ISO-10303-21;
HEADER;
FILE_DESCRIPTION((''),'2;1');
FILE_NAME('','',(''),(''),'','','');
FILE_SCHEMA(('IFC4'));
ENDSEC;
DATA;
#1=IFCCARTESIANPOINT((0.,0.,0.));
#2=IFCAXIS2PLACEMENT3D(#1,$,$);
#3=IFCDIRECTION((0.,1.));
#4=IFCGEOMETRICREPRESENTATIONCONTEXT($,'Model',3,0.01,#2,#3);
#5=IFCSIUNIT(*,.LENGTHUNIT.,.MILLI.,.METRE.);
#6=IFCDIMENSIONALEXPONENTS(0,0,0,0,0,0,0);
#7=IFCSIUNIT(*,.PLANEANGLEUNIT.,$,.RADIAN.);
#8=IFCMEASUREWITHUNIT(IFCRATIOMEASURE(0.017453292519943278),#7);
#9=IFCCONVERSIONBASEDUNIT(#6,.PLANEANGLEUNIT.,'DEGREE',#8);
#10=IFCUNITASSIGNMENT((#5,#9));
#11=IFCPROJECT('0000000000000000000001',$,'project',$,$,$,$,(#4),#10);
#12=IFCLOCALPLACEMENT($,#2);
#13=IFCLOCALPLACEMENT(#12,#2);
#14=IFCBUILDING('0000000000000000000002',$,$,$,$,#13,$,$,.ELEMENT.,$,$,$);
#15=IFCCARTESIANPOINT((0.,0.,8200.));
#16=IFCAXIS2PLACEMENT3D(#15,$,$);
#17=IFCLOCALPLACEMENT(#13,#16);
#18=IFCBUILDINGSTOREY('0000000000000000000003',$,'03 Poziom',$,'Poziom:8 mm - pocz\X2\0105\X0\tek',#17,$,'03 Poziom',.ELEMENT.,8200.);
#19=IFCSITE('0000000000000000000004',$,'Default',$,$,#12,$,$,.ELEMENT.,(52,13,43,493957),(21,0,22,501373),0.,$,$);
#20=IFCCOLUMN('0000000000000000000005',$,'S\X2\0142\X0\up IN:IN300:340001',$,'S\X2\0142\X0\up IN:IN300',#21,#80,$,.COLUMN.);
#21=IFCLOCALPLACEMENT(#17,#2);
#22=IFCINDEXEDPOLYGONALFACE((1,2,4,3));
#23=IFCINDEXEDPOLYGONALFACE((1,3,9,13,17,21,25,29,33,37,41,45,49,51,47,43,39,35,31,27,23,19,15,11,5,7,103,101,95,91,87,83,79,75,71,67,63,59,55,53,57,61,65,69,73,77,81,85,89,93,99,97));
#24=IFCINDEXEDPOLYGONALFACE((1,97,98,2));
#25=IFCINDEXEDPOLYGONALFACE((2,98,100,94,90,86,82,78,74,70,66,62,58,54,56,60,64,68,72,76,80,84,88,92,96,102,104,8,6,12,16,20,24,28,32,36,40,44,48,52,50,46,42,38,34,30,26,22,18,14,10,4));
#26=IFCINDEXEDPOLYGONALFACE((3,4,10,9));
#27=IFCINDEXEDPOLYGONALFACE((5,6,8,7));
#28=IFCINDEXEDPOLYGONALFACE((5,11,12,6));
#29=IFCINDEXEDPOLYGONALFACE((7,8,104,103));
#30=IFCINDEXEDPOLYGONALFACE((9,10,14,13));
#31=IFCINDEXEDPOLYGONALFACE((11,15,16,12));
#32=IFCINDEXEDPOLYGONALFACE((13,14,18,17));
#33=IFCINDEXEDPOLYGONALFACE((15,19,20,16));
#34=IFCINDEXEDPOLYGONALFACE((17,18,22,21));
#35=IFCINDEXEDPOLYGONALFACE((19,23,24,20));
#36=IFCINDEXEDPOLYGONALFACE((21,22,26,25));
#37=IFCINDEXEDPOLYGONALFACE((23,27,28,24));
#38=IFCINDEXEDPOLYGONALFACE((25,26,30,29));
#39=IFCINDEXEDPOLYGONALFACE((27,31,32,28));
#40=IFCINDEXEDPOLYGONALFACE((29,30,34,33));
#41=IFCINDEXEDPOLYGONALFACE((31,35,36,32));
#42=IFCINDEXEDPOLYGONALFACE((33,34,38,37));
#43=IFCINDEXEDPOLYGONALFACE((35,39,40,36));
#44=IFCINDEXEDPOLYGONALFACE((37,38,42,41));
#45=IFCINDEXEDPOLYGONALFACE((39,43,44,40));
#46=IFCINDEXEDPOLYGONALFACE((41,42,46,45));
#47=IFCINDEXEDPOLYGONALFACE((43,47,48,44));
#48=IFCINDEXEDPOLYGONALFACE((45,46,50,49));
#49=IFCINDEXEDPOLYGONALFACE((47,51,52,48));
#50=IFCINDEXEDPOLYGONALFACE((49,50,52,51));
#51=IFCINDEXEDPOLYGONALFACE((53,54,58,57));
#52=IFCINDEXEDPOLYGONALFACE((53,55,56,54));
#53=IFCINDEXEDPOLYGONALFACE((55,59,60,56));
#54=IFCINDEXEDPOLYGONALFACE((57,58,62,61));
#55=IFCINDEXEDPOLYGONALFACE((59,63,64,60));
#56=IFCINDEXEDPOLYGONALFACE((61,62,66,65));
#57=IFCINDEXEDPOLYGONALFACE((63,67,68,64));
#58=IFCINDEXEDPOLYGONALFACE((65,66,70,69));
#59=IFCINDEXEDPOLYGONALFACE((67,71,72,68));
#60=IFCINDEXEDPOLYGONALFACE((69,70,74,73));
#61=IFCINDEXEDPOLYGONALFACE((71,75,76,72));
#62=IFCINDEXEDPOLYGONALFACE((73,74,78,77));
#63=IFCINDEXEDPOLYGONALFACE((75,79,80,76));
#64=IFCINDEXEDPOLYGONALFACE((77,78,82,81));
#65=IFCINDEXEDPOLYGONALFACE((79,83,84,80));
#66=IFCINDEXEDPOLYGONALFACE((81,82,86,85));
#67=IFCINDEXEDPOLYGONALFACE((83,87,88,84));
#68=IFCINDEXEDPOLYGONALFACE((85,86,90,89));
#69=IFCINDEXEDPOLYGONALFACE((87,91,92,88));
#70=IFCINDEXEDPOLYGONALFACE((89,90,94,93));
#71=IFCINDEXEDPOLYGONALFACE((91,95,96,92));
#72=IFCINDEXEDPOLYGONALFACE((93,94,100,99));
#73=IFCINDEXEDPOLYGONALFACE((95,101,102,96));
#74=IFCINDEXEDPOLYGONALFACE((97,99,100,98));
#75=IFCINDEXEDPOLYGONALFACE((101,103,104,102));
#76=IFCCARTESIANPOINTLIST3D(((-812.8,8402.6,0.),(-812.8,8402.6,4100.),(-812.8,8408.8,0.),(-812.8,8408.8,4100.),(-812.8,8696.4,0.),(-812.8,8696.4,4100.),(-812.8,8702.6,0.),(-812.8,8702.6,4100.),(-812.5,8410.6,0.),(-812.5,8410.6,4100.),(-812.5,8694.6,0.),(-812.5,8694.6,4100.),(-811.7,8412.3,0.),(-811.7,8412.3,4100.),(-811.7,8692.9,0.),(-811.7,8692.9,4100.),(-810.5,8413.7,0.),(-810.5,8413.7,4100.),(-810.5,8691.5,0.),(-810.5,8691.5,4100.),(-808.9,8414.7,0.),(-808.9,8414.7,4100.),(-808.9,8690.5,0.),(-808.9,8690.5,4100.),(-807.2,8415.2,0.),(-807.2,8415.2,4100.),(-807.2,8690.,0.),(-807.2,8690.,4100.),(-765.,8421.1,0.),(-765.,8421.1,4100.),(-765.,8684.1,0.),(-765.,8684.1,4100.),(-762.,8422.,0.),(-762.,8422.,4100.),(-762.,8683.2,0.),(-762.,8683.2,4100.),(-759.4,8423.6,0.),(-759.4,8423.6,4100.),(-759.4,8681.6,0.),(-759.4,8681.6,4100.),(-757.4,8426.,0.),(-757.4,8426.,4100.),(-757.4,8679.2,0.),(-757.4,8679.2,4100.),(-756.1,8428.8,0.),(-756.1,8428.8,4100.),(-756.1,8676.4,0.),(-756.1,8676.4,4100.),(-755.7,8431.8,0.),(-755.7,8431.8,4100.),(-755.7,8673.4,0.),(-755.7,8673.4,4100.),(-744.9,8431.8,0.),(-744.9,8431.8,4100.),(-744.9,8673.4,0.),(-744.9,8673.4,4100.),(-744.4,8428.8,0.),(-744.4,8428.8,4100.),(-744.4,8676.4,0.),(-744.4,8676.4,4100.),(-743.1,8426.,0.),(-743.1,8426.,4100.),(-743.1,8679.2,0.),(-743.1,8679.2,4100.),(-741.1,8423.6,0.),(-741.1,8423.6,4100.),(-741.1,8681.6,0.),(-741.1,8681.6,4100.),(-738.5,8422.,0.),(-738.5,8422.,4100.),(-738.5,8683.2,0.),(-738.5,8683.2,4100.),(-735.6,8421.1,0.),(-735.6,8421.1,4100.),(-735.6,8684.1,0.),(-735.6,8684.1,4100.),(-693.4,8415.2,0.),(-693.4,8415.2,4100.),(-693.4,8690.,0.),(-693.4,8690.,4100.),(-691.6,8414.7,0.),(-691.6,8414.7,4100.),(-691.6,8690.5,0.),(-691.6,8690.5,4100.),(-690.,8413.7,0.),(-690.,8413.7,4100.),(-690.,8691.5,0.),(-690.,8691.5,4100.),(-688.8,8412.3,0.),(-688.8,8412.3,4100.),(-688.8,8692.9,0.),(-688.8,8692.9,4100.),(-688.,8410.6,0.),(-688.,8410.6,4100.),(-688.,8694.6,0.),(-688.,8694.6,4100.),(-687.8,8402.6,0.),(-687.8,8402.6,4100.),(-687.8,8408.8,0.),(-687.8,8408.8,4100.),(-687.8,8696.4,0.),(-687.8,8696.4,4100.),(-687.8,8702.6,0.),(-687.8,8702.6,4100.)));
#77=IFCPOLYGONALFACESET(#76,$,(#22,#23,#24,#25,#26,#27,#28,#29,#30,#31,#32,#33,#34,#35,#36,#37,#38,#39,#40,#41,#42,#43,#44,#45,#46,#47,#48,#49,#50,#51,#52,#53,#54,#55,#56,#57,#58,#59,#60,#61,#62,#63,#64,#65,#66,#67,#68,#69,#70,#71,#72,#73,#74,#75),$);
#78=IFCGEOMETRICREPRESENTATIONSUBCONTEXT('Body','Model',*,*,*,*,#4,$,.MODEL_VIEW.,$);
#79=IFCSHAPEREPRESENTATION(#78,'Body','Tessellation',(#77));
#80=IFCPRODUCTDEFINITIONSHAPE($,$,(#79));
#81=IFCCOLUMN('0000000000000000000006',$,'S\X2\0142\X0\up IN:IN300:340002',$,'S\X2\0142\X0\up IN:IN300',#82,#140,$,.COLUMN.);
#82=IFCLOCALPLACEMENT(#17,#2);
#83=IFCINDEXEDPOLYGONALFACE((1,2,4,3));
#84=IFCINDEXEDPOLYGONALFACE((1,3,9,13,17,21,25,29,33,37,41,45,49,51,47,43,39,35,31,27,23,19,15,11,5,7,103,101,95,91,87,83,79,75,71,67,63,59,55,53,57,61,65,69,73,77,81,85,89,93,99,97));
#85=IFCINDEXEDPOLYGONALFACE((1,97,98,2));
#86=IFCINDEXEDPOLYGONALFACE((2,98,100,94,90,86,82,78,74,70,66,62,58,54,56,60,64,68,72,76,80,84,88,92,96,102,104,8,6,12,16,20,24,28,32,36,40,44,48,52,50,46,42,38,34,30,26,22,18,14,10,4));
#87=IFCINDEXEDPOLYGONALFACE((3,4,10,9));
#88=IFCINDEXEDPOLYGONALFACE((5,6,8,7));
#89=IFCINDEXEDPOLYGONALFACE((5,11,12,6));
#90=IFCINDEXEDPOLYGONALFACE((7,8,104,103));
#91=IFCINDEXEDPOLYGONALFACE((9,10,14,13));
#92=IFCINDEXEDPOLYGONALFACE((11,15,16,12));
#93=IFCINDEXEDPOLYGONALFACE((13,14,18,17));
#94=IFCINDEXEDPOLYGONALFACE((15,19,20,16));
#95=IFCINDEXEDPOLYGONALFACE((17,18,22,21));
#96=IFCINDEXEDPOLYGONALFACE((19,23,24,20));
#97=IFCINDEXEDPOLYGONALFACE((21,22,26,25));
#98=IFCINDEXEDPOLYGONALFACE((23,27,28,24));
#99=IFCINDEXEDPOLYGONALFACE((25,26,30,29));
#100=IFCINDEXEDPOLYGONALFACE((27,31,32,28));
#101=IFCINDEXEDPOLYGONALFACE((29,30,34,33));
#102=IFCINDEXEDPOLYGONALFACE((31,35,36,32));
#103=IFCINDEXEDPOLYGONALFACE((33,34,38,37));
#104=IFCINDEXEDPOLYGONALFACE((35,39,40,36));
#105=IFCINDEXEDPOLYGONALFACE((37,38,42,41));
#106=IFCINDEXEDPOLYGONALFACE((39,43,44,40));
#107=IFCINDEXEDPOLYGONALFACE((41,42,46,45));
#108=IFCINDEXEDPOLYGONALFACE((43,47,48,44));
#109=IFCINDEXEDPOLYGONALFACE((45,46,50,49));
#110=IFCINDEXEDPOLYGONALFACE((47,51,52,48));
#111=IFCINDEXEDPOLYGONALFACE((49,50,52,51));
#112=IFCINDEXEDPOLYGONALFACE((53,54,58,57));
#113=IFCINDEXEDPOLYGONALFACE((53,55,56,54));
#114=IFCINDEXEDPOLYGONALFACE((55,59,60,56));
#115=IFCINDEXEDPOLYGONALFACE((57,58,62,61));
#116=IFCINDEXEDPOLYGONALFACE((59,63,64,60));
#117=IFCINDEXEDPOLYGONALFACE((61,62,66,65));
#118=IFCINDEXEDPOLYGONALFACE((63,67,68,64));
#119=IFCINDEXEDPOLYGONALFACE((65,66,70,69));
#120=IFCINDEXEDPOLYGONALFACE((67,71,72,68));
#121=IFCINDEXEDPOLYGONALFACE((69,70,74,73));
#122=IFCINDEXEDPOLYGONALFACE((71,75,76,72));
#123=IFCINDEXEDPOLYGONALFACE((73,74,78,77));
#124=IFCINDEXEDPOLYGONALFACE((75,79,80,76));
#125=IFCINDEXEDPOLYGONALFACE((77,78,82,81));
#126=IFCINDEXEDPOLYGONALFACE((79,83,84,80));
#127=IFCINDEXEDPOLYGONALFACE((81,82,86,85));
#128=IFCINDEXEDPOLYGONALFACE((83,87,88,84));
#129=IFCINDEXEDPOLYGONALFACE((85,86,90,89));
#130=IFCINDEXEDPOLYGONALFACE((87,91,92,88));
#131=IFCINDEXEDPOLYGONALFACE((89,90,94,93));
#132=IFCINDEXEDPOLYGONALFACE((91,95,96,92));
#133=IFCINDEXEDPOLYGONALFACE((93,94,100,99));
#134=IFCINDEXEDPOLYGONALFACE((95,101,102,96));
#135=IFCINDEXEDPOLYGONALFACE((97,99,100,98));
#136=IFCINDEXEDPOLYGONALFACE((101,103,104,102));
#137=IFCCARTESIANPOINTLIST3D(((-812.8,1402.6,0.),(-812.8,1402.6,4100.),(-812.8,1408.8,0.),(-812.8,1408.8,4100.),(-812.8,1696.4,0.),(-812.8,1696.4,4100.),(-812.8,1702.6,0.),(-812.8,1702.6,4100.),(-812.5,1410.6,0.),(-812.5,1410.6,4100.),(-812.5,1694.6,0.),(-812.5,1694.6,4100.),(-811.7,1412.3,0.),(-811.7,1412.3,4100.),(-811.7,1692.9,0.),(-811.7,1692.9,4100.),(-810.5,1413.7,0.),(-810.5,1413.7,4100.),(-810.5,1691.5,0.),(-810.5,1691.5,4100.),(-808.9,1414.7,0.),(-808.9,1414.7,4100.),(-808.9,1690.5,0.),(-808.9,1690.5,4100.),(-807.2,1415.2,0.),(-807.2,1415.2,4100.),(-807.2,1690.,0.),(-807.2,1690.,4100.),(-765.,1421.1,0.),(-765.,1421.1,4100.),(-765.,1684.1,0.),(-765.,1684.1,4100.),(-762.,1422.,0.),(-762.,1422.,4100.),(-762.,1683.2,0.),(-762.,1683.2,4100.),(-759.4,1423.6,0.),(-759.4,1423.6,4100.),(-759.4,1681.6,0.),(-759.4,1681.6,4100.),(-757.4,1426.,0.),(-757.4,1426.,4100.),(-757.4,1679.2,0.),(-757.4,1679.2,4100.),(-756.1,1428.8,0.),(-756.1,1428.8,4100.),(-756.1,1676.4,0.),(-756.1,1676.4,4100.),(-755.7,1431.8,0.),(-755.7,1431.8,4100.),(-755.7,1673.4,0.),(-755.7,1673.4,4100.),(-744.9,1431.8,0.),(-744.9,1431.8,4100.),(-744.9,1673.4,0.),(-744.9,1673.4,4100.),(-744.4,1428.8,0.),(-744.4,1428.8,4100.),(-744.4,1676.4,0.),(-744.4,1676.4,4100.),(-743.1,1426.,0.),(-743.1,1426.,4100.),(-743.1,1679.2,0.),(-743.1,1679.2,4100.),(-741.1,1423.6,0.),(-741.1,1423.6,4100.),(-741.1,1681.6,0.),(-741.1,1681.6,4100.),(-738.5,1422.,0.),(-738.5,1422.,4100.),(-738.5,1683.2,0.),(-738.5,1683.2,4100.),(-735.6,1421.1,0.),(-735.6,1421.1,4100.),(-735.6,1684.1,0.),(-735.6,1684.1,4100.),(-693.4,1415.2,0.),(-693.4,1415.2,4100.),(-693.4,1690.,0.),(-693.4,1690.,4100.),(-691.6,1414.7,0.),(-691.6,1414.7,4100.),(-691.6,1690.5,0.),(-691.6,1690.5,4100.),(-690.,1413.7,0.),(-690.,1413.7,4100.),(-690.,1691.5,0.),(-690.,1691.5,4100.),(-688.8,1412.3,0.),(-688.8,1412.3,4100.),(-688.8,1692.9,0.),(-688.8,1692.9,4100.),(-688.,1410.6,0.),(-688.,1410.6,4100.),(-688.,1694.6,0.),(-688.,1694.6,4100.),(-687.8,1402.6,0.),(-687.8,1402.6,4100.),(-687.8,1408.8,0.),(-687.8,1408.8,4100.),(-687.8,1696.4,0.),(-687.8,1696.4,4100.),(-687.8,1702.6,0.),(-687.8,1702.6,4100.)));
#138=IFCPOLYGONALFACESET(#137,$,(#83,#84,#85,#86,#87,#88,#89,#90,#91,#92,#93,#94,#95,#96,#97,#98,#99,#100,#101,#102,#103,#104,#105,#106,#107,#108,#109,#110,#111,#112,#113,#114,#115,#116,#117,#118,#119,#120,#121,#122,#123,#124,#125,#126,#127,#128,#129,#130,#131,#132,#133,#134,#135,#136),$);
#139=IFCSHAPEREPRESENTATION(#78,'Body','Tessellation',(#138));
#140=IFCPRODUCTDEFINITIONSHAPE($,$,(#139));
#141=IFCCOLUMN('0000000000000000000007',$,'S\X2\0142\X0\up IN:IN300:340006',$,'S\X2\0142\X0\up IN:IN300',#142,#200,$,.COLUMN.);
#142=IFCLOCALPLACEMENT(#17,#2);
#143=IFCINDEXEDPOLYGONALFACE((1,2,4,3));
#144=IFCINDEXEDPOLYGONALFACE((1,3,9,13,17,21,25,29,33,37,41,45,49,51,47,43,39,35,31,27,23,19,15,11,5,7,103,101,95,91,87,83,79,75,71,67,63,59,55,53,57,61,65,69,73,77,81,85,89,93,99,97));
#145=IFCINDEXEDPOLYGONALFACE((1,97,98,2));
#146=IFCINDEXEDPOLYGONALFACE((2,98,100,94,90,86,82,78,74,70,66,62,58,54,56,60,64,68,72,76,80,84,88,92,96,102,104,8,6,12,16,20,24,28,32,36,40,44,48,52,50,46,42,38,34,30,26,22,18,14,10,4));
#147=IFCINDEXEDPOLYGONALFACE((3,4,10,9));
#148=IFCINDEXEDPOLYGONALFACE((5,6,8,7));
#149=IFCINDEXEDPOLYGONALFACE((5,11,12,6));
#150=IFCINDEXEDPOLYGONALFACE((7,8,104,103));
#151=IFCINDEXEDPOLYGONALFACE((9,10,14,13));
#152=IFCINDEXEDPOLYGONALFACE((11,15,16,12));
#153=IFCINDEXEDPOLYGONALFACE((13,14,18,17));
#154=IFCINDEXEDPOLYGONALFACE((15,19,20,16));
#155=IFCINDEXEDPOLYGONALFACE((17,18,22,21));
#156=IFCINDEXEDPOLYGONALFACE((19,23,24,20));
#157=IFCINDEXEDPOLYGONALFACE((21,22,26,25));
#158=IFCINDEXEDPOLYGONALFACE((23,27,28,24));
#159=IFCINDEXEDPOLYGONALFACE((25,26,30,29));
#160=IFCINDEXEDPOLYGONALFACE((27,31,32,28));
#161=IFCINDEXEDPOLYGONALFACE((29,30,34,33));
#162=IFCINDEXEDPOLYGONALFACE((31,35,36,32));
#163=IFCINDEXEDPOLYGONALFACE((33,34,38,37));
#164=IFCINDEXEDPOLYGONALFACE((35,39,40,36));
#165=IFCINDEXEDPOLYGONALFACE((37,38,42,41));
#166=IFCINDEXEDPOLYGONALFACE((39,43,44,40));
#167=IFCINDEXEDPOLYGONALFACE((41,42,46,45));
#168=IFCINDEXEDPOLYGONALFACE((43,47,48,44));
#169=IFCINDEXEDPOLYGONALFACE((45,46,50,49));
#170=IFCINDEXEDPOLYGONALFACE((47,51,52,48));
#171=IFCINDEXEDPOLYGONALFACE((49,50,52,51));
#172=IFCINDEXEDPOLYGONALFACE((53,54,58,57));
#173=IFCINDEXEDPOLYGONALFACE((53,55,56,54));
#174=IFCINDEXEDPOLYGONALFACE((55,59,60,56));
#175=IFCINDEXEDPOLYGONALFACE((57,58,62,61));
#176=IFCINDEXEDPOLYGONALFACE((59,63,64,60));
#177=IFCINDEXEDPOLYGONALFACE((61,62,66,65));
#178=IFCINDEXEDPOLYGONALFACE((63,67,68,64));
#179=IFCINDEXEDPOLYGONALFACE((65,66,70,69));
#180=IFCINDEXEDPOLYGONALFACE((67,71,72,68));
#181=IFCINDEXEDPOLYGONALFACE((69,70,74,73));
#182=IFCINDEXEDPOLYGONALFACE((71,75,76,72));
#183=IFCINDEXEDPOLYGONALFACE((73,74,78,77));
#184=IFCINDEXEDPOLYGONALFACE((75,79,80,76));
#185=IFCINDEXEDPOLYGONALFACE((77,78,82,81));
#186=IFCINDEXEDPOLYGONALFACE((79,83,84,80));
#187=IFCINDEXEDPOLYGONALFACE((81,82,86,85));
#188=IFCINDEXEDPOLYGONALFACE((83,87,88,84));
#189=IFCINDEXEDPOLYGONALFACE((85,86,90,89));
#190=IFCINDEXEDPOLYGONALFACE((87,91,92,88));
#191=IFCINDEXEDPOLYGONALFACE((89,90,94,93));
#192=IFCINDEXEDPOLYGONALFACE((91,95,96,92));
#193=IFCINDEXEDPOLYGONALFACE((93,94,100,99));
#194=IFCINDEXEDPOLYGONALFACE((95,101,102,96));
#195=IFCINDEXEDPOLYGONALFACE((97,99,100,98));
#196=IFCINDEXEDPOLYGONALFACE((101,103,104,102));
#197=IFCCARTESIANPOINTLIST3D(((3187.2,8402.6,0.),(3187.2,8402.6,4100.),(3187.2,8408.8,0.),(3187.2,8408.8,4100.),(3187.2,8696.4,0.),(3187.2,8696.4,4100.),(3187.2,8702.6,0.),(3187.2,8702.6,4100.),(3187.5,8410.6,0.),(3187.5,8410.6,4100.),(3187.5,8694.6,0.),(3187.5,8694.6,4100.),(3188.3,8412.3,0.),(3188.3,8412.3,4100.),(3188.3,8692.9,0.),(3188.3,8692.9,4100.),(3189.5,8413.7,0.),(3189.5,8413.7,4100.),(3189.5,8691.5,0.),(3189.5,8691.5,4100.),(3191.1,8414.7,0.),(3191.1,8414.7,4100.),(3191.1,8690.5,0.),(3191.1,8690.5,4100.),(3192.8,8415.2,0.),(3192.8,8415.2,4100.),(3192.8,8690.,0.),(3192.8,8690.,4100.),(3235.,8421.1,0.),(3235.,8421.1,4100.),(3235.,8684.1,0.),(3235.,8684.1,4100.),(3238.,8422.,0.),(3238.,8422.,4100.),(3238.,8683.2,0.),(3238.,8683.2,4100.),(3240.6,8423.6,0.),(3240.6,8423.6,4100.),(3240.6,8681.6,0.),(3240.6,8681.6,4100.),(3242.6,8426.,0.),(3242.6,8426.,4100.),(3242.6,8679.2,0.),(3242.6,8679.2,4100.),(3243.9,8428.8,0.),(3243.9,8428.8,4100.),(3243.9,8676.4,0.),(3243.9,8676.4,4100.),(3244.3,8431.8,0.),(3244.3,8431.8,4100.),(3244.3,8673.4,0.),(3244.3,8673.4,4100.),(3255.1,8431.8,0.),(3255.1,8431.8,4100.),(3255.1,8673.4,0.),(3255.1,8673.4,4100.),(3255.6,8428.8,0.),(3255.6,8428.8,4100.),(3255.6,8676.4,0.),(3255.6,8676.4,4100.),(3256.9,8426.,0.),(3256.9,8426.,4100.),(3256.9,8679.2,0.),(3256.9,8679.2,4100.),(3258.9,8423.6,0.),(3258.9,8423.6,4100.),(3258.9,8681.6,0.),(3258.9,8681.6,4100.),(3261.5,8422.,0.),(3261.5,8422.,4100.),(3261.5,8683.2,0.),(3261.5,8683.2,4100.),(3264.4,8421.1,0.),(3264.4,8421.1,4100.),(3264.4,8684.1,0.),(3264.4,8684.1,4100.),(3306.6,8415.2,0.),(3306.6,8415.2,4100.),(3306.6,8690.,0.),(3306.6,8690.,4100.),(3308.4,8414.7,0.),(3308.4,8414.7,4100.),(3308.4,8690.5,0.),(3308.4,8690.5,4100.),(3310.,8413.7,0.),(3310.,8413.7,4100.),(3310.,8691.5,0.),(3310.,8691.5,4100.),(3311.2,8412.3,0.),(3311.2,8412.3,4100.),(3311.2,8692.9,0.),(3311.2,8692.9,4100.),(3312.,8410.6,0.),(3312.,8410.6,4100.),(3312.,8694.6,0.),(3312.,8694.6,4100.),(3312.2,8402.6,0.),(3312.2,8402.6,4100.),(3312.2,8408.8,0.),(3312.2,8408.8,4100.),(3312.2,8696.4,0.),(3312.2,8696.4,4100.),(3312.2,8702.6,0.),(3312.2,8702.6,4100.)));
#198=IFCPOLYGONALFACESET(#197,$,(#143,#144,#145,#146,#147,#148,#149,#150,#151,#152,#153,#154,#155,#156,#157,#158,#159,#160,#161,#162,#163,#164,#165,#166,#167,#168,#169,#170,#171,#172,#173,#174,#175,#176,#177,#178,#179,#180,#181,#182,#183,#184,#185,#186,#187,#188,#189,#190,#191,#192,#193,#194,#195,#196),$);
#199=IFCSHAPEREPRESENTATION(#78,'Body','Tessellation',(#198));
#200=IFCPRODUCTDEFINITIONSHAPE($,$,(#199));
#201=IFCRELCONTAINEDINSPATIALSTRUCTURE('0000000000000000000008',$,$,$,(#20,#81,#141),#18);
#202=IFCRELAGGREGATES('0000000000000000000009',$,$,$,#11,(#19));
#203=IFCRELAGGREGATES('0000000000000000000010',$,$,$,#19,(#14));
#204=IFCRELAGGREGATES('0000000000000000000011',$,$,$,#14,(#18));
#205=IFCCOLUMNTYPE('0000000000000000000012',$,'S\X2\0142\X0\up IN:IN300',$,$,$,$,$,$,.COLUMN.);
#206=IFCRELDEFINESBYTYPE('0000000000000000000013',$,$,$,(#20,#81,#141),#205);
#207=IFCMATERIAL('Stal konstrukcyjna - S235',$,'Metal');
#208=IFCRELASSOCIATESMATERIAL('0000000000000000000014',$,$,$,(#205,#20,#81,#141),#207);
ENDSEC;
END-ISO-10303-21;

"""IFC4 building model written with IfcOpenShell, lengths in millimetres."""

from ifc_helpers import new_model, entity, si_unit, converted_unit, direction, frame, origin, place, context, subcontext, project, spatial, line, arc, indexed_curve, outline, extrude, source, transform, mapped, material, type_object, type_shapes, element, save


model = new_model("IFC4")

# Units and contexts
model_context = context("Model", 3, precision=0.01, world=origin(), true_north=direction((0.0, 1.0)))
body_context = subcontext(model_context, "Body", "Model", "MODEL_VIEW")
ifc_project = project(units=[si_unit("LENGTHUNIT", "METRE", prefix="MILLI"), converted_unit("PLANEANGLEUNIT", "DEGREE", entity("IfcRatioMeasure", 0.017453292519943278), si_unit("PLANEANGLEUNIT", "RADIAN"), dimensions=[0, 0, 0, 0, 0, 0, 0])], contexts=[model_context])

# Site, building, storey
site_placement = place(None, origin())
site = spatial("IfcSite", under=ifc_project, at=site_placement, Name="Default", CompositionType="ELEMENT", RefLatitude=(52, 13, 43, 493957), RefLongitude=(21, 0, 22, 501373), RefElevation=0.0)
building_placement = place(site_placement, origin())
building = spatial("IfcBuilding", under=site, at=building_placement, CompositionType="ELEMENT")
storey_placement = place(building_placement, frame((0.0, 0.0, 8200.0)))
storey = spatial("IfcBuildingStorey", under=building, at=storey_placement, Name="03 Poziom", ObjectType="Poziom:8 mm - początek", LongName="03 Poziom", CompositionType="ELEMENT", Elevation=8200.0)

# Columns
ifc_material_1 = material(Name="Stal konstrukcyjna - S235", Category="Metal")
column_type = type_object("IfcColumnType", Name="Słup IN:IN300", PredefinedType="COLUMN", material=ifc_material_1)
shared_shape_1 = source(origin(), body_context, "Body", "SweptSolid", [
    extrude(outline(indexed_curve([(143.8, -62.5), (150.0, -62.5), (150.0, 62.5), (143.8, 62.5), (139.6, 60.9), (137.4, 56.9), (131.5, 14.7), (127.9, 8.1), (120.8, 5.4), (-120.8, 5.4), (-127.9, 8.1), (-131.5, 14.7), (-137.4, 56.9), (-139.6, 60.9), (-143.8, 62.5), (-150.0, 62.5), (-150.0, -62.5), (-143.8, -62.5), (-139.6, -60.9), (-137.4, -56.9), (-131.5, -14.7), (-127.9, -8.1), (-120.8, -5.4), (120.8, -5.4), (127.9, -8.1), (131.5, -14.7), (137.4, -56.9), (139.6, -60.9)], segments=[line(1, 2, 3, 4), arc(4, 5, 6), line(6, 7), arc(7, 8, 9), line(9, 10), arc(10, 11, 12), line(12, 13), arc(13, 14, 15), line(15, 16, 17, 18), arc(18, 19, 20), line(20, 21), arc(21, 22, 23), line(23, 24), arc(24, 25, 26), line(26, 27), arc(27, 28, 1)], self_intersect=False)), frame((0.0, 0.0, 8200.0), z_axis=(0.0, 0.0, 1.0), x_axis=(0.0, -1.0, 0.0)), (0.0, 0.0, 1.0), 4100.0),
])
type_shapes(column_type, [shared_shape_1])
for number, where, name in (
    (1, (-750.3, 8552.6, -8200.0), "Słup IN:IN300:340001"),
    (2, (-750.3, 1552.6, -8200.0), "Słup IN:IN300:340002"),
    (3, (3249.7, 8552.6, -8200.0), "Słup IN:IN300:340006"),
):
    element("IfcColumn", number, at=place(storey_placement, frame(where)), inside=storey, type_object=column_type, material=ifc_material_1, Name=name, ObjectType="Słup IN:IN300", PredefinedType="COLUMN", context=body_context, shape_type="MappedRepresentation", body=[
        mapped(shared_shape_1, transform((0.0, 0.0, 0.0), scale=1.0)),
    ])

save(model, "model.ifc")
